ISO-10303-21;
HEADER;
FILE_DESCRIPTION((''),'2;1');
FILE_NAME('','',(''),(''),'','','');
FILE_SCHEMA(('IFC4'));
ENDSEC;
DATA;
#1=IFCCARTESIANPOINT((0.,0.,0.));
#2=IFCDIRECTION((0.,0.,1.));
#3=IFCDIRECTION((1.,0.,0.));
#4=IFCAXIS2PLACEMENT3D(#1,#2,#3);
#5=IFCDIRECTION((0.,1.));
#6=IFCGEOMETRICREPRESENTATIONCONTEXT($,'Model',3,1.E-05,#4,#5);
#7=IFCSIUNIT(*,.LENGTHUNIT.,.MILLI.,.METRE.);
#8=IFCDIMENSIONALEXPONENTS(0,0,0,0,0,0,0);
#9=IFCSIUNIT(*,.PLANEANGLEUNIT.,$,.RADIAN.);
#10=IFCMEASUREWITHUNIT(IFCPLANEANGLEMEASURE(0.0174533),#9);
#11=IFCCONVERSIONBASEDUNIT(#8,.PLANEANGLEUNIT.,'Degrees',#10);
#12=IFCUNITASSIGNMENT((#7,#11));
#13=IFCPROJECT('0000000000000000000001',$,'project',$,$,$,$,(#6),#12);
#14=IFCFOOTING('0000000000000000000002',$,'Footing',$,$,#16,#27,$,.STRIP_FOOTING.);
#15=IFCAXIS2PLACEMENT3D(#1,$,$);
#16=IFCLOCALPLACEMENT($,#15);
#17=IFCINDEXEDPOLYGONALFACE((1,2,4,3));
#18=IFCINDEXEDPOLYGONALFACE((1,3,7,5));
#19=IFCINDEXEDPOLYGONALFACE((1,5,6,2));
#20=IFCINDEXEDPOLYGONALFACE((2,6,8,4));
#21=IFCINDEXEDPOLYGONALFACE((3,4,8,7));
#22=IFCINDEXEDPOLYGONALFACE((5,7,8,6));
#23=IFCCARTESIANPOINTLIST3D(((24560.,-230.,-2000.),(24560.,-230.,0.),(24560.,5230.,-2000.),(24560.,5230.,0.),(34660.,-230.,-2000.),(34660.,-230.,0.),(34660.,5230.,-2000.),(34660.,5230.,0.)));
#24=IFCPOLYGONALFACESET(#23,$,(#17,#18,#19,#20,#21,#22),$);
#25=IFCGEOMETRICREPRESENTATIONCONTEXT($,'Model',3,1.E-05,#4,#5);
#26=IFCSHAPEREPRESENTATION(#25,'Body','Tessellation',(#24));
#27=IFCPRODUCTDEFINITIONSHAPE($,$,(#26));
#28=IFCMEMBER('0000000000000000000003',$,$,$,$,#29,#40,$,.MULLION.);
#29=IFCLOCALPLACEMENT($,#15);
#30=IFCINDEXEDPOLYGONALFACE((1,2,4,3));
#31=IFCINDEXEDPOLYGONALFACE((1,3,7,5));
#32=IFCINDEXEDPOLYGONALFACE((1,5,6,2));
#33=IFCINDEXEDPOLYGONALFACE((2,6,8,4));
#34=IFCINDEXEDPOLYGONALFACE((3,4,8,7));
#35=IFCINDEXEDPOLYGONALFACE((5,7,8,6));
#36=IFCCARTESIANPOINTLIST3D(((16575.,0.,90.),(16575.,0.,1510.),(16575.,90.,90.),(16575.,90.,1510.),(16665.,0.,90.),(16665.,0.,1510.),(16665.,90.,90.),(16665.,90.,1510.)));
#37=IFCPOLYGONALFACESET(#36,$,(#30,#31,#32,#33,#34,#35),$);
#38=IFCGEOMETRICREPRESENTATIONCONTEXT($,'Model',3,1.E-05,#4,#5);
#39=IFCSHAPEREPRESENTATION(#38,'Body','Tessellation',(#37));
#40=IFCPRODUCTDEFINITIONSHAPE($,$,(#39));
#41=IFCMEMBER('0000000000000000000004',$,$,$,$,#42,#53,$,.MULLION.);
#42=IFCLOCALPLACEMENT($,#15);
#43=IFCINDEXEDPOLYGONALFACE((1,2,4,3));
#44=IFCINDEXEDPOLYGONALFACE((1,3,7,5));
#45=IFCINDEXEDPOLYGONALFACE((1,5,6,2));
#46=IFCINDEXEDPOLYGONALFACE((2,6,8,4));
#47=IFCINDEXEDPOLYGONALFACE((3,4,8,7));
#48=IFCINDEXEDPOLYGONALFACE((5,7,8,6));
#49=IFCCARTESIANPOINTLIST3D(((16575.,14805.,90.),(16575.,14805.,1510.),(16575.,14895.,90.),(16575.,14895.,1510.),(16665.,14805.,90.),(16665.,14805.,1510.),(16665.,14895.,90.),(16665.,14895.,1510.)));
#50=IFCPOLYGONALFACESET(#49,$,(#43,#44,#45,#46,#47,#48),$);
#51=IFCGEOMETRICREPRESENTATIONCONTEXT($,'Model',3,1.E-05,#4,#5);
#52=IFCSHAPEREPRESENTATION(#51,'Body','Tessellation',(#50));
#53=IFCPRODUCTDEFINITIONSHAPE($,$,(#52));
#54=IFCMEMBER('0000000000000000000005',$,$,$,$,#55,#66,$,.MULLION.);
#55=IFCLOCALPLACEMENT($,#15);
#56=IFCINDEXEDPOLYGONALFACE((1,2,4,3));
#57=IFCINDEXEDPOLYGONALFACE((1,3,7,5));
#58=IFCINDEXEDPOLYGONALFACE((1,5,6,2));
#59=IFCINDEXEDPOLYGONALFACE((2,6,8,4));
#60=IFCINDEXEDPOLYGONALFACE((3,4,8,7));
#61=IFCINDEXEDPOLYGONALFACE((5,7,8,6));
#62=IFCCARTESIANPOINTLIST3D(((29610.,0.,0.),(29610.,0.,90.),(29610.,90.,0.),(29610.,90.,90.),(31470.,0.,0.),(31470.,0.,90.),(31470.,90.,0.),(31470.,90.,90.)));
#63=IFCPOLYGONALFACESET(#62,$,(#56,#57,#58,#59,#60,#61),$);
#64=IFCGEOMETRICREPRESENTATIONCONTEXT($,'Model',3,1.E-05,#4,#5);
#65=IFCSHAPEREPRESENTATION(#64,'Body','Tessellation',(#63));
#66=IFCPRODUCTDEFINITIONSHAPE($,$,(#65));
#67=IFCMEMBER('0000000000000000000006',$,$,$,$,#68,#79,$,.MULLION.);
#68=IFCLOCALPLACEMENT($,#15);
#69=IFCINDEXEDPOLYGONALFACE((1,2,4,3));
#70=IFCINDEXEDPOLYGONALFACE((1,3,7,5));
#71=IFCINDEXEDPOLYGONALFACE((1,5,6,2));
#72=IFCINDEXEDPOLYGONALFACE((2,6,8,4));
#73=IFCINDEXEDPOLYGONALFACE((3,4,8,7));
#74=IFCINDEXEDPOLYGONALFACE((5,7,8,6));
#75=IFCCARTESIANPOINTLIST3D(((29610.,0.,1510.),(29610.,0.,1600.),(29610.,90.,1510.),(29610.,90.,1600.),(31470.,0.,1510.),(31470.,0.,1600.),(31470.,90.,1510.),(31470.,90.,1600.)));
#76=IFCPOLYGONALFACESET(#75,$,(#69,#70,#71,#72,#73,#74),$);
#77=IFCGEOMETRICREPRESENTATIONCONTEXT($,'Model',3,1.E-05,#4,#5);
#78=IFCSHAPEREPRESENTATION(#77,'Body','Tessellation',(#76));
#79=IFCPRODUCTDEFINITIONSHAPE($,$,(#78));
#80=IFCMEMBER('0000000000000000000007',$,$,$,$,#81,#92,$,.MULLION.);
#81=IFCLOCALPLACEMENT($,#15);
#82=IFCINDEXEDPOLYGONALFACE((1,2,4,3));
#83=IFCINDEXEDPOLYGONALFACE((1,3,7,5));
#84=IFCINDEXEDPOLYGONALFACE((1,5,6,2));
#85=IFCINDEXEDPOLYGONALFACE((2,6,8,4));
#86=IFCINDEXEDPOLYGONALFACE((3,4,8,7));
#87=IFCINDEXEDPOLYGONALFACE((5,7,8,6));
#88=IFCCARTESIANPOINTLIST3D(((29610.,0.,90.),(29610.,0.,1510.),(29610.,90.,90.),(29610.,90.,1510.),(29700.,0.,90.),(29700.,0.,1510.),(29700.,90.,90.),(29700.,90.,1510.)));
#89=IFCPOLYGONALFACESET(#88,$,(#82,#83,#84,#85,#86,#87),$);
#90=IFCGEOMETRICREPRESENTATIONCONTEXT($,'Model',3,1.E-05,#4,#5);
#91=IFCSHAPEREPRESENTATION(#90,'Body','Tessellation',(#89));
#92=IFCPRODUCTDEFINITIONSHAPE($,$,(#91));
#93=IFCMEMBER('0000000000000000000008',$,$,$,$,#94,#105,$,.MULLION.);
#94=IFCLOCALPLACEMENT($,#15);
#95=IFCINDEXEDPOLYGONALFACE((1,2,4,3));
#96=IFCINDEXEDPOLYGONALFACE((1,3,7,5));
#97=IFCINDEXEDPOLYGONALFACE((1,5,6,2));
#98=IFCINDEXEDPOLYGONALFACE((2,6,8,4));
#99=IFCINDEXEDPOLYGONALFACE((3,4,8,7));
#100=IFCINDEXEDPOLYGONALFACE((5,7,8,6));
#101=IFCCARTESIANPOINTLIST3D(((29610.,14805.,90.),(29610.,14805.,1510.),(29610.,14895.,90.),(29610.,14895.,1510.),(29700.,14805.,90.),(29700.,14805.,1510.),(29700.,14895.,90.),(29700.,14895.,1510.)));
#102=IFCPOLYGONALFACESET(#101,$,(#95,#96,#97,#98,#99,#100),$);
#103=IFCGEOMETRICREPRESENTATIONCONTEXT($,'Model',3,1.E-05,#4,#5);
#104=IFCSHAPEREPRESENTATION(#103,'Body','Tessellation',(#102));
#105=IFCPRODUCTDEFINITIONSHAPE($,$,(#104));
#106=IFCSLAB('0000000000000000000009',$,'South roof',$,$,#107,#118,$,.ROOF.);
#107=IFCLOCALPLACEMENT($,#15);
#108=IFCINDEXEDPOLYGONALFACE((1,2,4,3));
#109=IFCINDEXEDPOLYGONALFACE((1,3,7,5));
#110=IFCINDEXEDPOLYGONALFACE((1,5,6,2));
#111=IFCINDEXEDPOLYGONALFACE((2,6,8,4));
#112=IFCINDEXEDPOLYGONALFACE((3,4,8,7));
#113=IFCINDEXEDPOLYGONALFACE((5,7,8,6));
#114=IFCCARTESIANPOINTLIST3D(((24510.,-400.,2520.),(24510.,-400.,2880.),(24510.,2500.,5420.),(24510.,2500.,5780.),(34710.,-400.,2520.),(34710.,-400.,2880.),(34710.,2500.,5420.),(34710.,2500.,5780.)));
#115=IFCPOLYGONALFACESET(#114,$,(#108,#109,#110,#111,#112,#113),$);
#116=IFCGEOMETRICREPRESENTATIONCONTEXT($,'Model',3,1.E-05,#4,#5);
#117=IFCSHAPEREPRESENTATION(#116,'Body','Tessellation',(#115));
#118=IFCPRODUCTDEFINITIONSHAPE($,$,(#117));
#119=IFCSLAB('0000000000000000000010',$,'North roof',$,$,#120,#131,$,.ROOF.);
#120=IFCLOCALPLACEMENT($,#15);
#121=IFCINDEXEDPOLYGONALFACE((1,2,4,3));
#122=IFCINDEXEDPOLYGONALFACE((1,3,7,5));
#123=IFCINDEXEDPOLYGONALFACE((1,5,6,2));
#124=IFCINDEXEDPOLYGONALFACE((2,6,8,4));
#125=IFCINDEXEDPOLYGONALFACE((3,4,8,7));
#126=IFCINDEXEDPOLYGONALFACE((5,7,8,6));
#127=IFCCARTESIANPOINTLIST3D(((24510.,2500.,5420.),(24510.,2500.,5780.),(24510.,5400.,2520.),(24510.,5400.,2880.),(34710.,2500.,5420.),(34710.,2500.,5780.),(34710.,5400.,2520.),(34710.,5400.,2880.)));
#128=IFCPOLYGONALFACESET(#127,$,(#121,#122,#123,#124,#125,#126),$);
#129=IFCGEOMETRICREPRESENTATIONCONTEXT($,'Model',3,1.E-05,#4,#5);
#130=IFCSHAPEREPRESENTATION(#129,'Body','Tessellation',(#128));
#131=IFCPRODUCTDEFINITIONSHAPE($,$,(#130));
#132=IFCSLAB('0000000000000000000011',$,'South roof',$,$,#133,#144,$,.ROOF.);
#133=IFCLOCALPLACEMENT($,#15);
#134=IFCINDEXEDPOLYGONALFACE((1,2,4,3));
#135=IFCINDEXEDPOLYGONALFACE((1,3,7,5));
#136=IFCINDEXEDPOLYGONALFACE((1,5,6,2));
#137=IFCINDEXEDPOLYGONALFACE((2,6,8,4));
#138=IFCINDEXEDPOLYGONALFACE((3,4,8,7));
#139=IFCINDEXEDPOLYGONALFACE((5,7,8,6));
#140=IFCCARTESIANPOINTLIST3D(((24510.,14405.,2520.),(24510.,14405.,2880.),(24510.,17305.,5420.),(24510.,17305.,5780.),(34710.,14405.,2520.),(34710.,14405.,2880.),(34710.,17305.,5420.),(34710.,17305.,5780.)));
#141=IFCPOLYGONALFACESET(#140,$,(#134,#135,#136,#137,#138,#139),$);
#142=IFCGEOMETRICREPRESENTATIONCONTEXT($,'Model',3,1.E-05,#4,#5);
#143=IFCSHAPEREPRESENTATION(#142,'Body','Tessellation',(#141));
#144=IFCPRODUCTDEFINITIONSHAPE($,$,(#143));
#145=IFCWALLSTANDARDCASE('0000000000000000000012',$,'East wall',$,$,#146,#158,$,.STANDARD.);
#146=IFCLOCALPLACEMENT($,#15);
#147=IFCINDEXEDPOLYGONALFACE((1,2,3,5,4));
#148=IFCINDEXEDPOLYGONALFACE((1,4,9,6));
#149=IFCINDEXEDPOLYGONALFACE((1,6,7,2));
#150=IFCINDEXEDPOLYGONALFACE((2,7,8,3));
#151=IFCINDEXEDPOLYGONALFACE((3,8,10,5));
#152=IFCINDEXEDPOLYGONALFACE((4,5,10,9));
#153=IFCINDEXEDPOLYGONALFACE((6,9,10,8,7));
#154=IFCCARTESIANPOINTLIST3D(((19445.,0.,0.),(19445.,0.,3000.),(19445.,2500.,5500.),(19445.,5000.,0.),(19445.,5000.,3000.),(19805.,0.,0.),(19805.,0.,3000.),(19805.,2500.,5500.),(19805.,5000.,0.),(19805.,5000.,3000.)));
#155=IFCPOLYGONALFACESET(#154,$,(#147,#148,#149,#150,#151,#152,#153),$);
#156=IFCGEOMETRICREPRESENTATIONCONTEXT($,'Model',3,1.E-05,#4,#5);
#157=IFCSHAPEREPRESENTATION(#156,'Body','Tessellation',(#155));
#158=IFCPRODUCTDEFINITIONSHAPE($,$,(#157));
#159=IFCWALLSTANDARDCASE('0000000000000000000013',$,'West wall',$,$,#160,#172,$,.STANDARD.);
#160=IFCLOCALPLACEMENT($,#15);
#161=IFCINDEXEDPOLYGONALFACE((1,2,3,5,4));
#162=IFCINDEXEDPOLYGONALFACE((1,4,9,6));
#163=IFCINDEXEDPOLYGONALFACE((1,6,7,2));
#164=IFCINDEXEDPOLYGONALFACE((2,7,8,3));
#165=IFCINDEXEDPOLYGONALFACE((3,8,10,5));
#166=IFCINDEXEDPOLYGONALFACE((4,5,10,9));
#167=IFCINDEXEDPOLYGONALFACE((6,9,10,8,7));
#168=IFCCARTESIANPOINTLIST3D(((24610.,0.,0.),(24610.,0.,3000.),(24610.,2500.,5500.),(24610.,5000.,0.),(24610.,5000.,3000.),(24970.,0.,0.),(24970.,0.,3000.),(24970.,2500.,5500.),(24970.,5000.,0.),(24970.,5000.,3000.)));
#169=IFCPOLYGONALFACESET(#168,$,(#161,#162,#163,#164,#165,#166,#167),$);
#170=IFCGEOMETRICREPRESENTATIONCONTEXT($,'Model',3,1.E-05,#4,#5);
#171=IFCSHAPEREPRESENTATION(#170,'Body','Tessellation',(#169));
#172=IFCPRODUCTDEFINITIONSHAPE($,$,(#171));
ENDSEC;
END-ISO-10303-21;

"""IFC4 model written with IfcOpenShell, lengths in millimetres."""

from ifc_helpers import new_model, entity, si_unit, converted_unit, direction, frame, origin_with_axes, place, context, project, polyline, outline, extrude, clip, halfspace, source, transform, mapped, element, save


model = new_model("IFC4")

# Units and contexts
model_context_1 = context("Model", 3, precision=1e-05, world=origin_with_axes(), true_north=direction((0.0, 1.0)))
model_context_2 = context("Model", 3, precision=1e-05, world=origin_with_axes(), true_north=direction((0.0, 1.0)))
model_context_3 = context("Model", 3, precision=1e-05, world=origin_with_axes(), true_north=direction((0.0, 1.0)))
model_context_4 = context("Model", 3, precision=1e-05, world=origin_with_axes(), true_north=direction((0.0, 1.0)))
model_context_5 = context("Model", 3, precision=1e-05, world=origin_with_axes(), true_north=direction((0.0, 1.0)))
model_context_6 = context("Model", 3, precision=1e-05, world=origin_with_axes(), true_north=direction((0.0, 1.0)))
model_context_7 = context("Model", 3, precision=1e-05, world=origin_with_axes(), true_north=direction((0.0, 1.0)))
model_context_8 = context("Model", 3, precision=1e-05, world=origin_with_axes(), true_north=direction((0.0, 1.0)))
model_context_9 = context("Model", 3, precision=1e-05, world=origin_with_axes(), true_north=direction((0.0, 1.0)))
model_context_10 = context("Model", 3, precision=1e-05, world=origin_with_axes(), true_north=direction((0.0, 1.0)))
model_context_11 = context("Model", 3, precision=1e-05, world=origin_with_axes(), true_north=direction((0.0, 1.0)))
model_context_12 = context("Model", 3, precision=1e-05, world=origin_with_axes(), true_north=direction((0.0, 1.0)))
model_context_13 = context("Model", 3, precision=1e-05, world=origin_with_axes(), true_north=direction((0.0, 1.0)))
ifc_project = project(units=[si_unit("LENGTHUNIT", "METRE", prefix="MILLI"), converted_unit("PLANEANGLEUNIT", "Degrees", entity("IfcPlaneAngleMeasure", 0.0174533), si_unit("PLANEANGLEUNIT", "RADIAN"), dimensions=[0, 0, 0, 0, 0, 0, 0])], contexts=[model_context_1])

# Footing
placement_1 = place(None, frame((29610.0, 0.0, 0.0)))
footing_placement = place(placement_1, frame((0.0, 2500.0, -2000.0), z_axis=(0.0, 0.0, 1.0), x_axis=(1.0, 0.0, 0.0)))
element("IfcFooting", 1, at=footing_placement, Name="Footing", PredefinedType="STRIP_FOOTING", context=model_context_5, shape_type="SweptSolid", body=[
    extrude(outline(polyline([(-5050.0, -2730.0), (5050.0, -2730.0), (5050.0, 2730.0), (-5050.0, 2730.0), (-5050.0, -2730.0), (-5050.0, -2730.0)])), origin_with_axes(), (0.0, 0.0, 1.0), 2000.0),
])

# Members
shared_shape_1 = source(origin_with_axes(), model_context_2, "Body", "SweptSolid", [
    extrude(outline(polyline([(-45.0, -45.0), (45.0, -45.0), (45.0, 45.0), (-45.0, 45.0), (-45.0, -45.0), (-45.0, -45.0)])), origin_with_axes(), (0.0, 0.0, 1.0), 1420.0),
])
placement_2 = place(None, frame((14805.0, 0.0, 0.0)))
member_1_placement = place(placement_2, frame((1815.0, 45.0, 90.0), z_axis=(0.0, 0.0, 1.0), x_axis=(1.0, 0.0, 0.0)))
element("IfcMember", 2, at=member_1_placement, PredefinedType="MULLION", context=model_context_2, shape_type="MappedRepresentation", body=[
    mapped(shared_shape_1, transform((0.0, 0.0, 0.0))),
])
shared_shape_2 = source(origin_with_axes(), model_context_4, "Body", "SweptSolid", [
    extrude(outline(polyline([(-45.0, -45.0), (45.0, -45.0), (45.0, 45.0), (-45.0, 45.0), (-45.0, -45.0), (-45.0, -45.0)])), origin_with_axes(), (0.0, 0.0, 1.0), 1420.0),
])
placement_3 = place(None, frame((14805.0, 14805.0, 0.0)))
member_2_placement = place(placement_3, frame((1815.0, 45.0, 90.0), z_axis=(0.0, 0.0, 1.0), x_axis=(1.0, 0.0, 0.0)))
element("IfcMember", 3, at=member_2_placement, PredefinedType="MULLION", context=model_context_4, shape_type="MappedRepresentation", body=[
    mapped(shared_shape_2, transform((0.0, 0.0, 0.0))),
])
shared_shape_3 = source(origin_with_axes(), model_context_6, "Body", "SweptSolid", [
    extrude(outline(polyline([(-930.0, -45.0), (930.0, -45.0), (930.0, 45.0), (-930.0, 45.0), (-930.0, -45.0), (-930.0, -45.0)])), origin_with_axes(), (0.0, 0.0, 1.0), 90.0),
])
member_3_placement = place(placement_1, frame((930.0, 45.0, 0.0), z_axis=(0.0, 0.0, 1.0), x_axis=(1.0, 0.0, 0.0)))
element("IfcMember", 4, at=member_3_placement, PredefinedType="MULLION", context=model_context_6, shape_type="MappedRepresentation", body=[
    mapped(shared_shape_3, transform((0.0, 0.0, 0.0))),
])
shared_shape_4 = source(origin_with_axes(), model_context_7, "Body", "SweptSolid", [
    extrude(outline(polyline([(-930.0, -45.0), (930.0, -45.0), (930.0, 45.0), (-930.0, 45.0), (-930.0, -45.0), (-930.0, -45.0)])), origin_with_axes(), (0.0, 0.0, 1.0), 90.0),
])
member_4_placement = place(placement_1, frame((930.0, 45.0, 1510.0), z_axis=(0.0, 0.0, 1.0), x_axis=(1.0, 0.0, 0.0)))
element("IfcMember", 5, at=member_4_placement, PredefinedType="MULLION", context=model_context_7, shape_type="MappedRepresentation", body=[
    mapped(shared_shape_4, transform((0.0, 0.0, 0.0))),
])
shared_shape_5 = source(origin_with_axes(), model_context_8, "Body", "SweptSolid", [
    extrude(outline(polyline([(-45.0, -45.0), (45.0, -45.0), (45.0, 45.0), (-45.0, 45.0), (-45.0, -45.0), (-45.0, -45.0)])), origin_with_axes(), (0.0, 0.0, 1.0), 1420.0),
])
member_5_placement = place(placement_1, frame((45.0, 45.0, 90.0), z_axis=(0.0, 0.0, 1.0), x_axis=(1.0, 0.0, 0.0)))
element("IfcMember", 6, at=member_5_placement, PredefinedType="MULLION", context=model_context_8, shape_type="MappedRepresentation", body=[
    mapped(shared_shape_5, transform((0.0, 0.0, 0.0))),
])
shared_shape_6 = source(origin_with_axes(), model_context_12, "Body", "SweptSolid", [
    extrude(outline(polyline([(-45.0, -45.0), (45.0, -45.0), (45.0, 45.0), (-45.0, 45.0), (-45.0, -45.0), (-45.0, -45.0)])), origin_with_axes(), (0.0, 0.0, 1.0), 1420.0),
])
placement_4 = place(None, frame((29610.0, 14805.0, 0.0)))
member_6_placement = place(placement_4, frame((45.0, 45.0, 90.0), z_axis=(0.0, 0.0, 1.0), x_axis=(1.0, 0.0, 0.0)))
element("IfcMember", 7, at=member_6_placement, PredefinedType="MULLION", context=model_context_12, shape_type="MappedRepresentation", body=[
    mapped(shared_shape_6, transform((0.0, 0.0, 0.0))),
])

# Slabs
shared_shape_7 = source(origin_with_axes(), model_context_9, "Body", "SweptSolid", [
    extrude(outline(polyline([(-5100.0, -180.0), (5100.0, -180.0), (5100.0, 180.0), (-5100.0, 180.0), (-5100.0, -180.0), (-5100.0, -180.0)])), frame((0.0, 0.0, 0.0), z_axis=(0.0, 1.0, 0.0), x_axis=(1.0, 0.0, 0.0)), (0.0, -0.707107, 0.707107), 4101.2),
])
slab_1_placement = place(placement_1, frame((0.0, -400.0, 2700.0), z_axis=(0.0, 0.0, 1.0), x_axis=(1.0, 0.0, 0.0)))
element("IfcSlab", 8, at=slab_1_placement, Name="South roof", PredefinedType="ROOF", context=model_context_9, shape_type="MappedRepresentation", body=[
    mapped(shared_shape_7, transform((0.0, 0.0, 0.0))),
])
shared_shape_8 = source(origin_with_axes(), model_context_10, "Body", "SweptSolid", [
    extrude(outline(polyline([(-5100.0, -180.0), (5100.0, -180.0), (5100.0, 180.0), (-5100.0, 180.0), (-5100.0, -180.0), (-5100.0, -180.0)])), frame((0.0, 0.0, 0.0), z_axis=(0.0, 1.0, 0.0), x_axis=(1.0, 0.0, 0.0)), (0.0, -0.707107, 0.707107), 4101.2),
])
slab_2_placement = place(placement_1, frame((0.0, 5400.0, 2700.0), z_axis=(0.0, 0.0, 1.0), x_axis=(-1.0, 0.0, 0.0)))
element("IfcSlab", 9, at=slab_2_placement, Name="North roof", PredefinedType="ROOF", context=model_context_10, shape_type="MappedRepresentation", body=[
    mapped(shared_shape_8, transform((0.0, 0.0, 0.0))),
])
shared_shape_9 = source(origin_with_axes(), model_context_13, "Body", "SweptSolid", [
    extrude(outline(polyline([(-5100.0, -180.0), (5100.0, -180.0), (5100.0, 180.0), (-5100.0, 180.0), (-5100.0, -180.0), (-5100.0, -180.0)])), frame((0.0, 0.0, 0.0), z_axis=(0.0, 1.0, 0.0), x_axis=(1.0, 0.0, 0.0)), (0.0, -0.707107, 0.707107), 4101.2),
])
slab_3_placement = place(placement_4, frame((0.0, -400.0, 2700.0), z_axis=(0.0, 0.0, 1.0), x_axis=(1.0, 0.0, 0.0)))
element("IfcSlab", 10, at=slab_3_placement, Name="South roof", PredefinedType="ROOF", context=model_context_13, shape_type="MappedRepresentation", body=[
    mapped(shared_shape_9, transform((0.0, 0.0, 0.0))),
])

# Walls
shared_shape_10 = source(origin_with_axes(), model_context_3, "Body", "Clipping", [
    clip(clip(extrude(outline(polyline([(-2500.0, -180.0), (2500.0, -180.0), (2500.0, 180.0), (-2500.0, 180.0), (-2500.0, -180.0), (-2500.0, -180.0)])), origin_with_axes(), (0.0, 0.0, 1.0), 6000.0), halfspace(frame((-2500.0, 0.0, 3000.0), z_axis=(-1.0, 0.0, 1.0), x_axis=(1.0, 0.0, 0.0)), False)), halfspace(frame((2500.0, 0.0, 3000.0), z_axis=(1.0, 0.0, 1.0), x_axis=(1.0, 0.0, 0.0)), False)),
])
wall_1_placement = place(placement_2, frame((4820.0, 2500.0, 0.0), z_axis=(0.0, 0.0, 1.0), x_axis=(0.0, 1.0, 0.0)))
element("IfcWallStandardCase", 11, at=wall_1_placement, Name="East wall", PredefinedType="STANDARD", context=model_context_3, shape_type="MappedRepresentation", body=[
    mapped(shared_shape_10, transform((0.0, 0.0, 0.0))),
])
shared_shape_11 = source(origin_with_axes(), model_context_11, "Body", "Clipping", [
    clip(clip(extrude(outline(polyline([(-2500.0, -180.0), (2500.0, -180.0), (2500.0, 180.0), (-2500.0, 180.0), (-2500.0, -180.0), (-2500.0, -180.0)])), origin_with_axes(), (0.0, 0.0, 1.0), 6000.0), halfspace(frame((-2500.0, 0.0, 3000.0), z_axis=(-1.0, 0.0, 1.0), x_axis=(1.0, 0.0, 0.0)), False)), halfspace(frame((2500.0, 0.0, 3000.0), z_axis=(1.0, 0.0, 1.0), x_axis=(1.0, 0.0, 0.0)), False)),
])
wall_2_placement = place(placement_1, frame((-4820.0, 2500.0, 0.0), z_axis=(0.0, 0.0, 1.0), x_axis=(0.0, -1.0, 0.0)))
element("IfcWallStandardCase", 12, at=wall_2_placement, Name="West wall", PredefinedType="STANDARD", context=model_context_11, shape_type="MappedRepresentation", body=[
    mapped(shared_shape_11, transform((0.0, 0.0, 0.0))),
])

save(model, "model.ifc")
